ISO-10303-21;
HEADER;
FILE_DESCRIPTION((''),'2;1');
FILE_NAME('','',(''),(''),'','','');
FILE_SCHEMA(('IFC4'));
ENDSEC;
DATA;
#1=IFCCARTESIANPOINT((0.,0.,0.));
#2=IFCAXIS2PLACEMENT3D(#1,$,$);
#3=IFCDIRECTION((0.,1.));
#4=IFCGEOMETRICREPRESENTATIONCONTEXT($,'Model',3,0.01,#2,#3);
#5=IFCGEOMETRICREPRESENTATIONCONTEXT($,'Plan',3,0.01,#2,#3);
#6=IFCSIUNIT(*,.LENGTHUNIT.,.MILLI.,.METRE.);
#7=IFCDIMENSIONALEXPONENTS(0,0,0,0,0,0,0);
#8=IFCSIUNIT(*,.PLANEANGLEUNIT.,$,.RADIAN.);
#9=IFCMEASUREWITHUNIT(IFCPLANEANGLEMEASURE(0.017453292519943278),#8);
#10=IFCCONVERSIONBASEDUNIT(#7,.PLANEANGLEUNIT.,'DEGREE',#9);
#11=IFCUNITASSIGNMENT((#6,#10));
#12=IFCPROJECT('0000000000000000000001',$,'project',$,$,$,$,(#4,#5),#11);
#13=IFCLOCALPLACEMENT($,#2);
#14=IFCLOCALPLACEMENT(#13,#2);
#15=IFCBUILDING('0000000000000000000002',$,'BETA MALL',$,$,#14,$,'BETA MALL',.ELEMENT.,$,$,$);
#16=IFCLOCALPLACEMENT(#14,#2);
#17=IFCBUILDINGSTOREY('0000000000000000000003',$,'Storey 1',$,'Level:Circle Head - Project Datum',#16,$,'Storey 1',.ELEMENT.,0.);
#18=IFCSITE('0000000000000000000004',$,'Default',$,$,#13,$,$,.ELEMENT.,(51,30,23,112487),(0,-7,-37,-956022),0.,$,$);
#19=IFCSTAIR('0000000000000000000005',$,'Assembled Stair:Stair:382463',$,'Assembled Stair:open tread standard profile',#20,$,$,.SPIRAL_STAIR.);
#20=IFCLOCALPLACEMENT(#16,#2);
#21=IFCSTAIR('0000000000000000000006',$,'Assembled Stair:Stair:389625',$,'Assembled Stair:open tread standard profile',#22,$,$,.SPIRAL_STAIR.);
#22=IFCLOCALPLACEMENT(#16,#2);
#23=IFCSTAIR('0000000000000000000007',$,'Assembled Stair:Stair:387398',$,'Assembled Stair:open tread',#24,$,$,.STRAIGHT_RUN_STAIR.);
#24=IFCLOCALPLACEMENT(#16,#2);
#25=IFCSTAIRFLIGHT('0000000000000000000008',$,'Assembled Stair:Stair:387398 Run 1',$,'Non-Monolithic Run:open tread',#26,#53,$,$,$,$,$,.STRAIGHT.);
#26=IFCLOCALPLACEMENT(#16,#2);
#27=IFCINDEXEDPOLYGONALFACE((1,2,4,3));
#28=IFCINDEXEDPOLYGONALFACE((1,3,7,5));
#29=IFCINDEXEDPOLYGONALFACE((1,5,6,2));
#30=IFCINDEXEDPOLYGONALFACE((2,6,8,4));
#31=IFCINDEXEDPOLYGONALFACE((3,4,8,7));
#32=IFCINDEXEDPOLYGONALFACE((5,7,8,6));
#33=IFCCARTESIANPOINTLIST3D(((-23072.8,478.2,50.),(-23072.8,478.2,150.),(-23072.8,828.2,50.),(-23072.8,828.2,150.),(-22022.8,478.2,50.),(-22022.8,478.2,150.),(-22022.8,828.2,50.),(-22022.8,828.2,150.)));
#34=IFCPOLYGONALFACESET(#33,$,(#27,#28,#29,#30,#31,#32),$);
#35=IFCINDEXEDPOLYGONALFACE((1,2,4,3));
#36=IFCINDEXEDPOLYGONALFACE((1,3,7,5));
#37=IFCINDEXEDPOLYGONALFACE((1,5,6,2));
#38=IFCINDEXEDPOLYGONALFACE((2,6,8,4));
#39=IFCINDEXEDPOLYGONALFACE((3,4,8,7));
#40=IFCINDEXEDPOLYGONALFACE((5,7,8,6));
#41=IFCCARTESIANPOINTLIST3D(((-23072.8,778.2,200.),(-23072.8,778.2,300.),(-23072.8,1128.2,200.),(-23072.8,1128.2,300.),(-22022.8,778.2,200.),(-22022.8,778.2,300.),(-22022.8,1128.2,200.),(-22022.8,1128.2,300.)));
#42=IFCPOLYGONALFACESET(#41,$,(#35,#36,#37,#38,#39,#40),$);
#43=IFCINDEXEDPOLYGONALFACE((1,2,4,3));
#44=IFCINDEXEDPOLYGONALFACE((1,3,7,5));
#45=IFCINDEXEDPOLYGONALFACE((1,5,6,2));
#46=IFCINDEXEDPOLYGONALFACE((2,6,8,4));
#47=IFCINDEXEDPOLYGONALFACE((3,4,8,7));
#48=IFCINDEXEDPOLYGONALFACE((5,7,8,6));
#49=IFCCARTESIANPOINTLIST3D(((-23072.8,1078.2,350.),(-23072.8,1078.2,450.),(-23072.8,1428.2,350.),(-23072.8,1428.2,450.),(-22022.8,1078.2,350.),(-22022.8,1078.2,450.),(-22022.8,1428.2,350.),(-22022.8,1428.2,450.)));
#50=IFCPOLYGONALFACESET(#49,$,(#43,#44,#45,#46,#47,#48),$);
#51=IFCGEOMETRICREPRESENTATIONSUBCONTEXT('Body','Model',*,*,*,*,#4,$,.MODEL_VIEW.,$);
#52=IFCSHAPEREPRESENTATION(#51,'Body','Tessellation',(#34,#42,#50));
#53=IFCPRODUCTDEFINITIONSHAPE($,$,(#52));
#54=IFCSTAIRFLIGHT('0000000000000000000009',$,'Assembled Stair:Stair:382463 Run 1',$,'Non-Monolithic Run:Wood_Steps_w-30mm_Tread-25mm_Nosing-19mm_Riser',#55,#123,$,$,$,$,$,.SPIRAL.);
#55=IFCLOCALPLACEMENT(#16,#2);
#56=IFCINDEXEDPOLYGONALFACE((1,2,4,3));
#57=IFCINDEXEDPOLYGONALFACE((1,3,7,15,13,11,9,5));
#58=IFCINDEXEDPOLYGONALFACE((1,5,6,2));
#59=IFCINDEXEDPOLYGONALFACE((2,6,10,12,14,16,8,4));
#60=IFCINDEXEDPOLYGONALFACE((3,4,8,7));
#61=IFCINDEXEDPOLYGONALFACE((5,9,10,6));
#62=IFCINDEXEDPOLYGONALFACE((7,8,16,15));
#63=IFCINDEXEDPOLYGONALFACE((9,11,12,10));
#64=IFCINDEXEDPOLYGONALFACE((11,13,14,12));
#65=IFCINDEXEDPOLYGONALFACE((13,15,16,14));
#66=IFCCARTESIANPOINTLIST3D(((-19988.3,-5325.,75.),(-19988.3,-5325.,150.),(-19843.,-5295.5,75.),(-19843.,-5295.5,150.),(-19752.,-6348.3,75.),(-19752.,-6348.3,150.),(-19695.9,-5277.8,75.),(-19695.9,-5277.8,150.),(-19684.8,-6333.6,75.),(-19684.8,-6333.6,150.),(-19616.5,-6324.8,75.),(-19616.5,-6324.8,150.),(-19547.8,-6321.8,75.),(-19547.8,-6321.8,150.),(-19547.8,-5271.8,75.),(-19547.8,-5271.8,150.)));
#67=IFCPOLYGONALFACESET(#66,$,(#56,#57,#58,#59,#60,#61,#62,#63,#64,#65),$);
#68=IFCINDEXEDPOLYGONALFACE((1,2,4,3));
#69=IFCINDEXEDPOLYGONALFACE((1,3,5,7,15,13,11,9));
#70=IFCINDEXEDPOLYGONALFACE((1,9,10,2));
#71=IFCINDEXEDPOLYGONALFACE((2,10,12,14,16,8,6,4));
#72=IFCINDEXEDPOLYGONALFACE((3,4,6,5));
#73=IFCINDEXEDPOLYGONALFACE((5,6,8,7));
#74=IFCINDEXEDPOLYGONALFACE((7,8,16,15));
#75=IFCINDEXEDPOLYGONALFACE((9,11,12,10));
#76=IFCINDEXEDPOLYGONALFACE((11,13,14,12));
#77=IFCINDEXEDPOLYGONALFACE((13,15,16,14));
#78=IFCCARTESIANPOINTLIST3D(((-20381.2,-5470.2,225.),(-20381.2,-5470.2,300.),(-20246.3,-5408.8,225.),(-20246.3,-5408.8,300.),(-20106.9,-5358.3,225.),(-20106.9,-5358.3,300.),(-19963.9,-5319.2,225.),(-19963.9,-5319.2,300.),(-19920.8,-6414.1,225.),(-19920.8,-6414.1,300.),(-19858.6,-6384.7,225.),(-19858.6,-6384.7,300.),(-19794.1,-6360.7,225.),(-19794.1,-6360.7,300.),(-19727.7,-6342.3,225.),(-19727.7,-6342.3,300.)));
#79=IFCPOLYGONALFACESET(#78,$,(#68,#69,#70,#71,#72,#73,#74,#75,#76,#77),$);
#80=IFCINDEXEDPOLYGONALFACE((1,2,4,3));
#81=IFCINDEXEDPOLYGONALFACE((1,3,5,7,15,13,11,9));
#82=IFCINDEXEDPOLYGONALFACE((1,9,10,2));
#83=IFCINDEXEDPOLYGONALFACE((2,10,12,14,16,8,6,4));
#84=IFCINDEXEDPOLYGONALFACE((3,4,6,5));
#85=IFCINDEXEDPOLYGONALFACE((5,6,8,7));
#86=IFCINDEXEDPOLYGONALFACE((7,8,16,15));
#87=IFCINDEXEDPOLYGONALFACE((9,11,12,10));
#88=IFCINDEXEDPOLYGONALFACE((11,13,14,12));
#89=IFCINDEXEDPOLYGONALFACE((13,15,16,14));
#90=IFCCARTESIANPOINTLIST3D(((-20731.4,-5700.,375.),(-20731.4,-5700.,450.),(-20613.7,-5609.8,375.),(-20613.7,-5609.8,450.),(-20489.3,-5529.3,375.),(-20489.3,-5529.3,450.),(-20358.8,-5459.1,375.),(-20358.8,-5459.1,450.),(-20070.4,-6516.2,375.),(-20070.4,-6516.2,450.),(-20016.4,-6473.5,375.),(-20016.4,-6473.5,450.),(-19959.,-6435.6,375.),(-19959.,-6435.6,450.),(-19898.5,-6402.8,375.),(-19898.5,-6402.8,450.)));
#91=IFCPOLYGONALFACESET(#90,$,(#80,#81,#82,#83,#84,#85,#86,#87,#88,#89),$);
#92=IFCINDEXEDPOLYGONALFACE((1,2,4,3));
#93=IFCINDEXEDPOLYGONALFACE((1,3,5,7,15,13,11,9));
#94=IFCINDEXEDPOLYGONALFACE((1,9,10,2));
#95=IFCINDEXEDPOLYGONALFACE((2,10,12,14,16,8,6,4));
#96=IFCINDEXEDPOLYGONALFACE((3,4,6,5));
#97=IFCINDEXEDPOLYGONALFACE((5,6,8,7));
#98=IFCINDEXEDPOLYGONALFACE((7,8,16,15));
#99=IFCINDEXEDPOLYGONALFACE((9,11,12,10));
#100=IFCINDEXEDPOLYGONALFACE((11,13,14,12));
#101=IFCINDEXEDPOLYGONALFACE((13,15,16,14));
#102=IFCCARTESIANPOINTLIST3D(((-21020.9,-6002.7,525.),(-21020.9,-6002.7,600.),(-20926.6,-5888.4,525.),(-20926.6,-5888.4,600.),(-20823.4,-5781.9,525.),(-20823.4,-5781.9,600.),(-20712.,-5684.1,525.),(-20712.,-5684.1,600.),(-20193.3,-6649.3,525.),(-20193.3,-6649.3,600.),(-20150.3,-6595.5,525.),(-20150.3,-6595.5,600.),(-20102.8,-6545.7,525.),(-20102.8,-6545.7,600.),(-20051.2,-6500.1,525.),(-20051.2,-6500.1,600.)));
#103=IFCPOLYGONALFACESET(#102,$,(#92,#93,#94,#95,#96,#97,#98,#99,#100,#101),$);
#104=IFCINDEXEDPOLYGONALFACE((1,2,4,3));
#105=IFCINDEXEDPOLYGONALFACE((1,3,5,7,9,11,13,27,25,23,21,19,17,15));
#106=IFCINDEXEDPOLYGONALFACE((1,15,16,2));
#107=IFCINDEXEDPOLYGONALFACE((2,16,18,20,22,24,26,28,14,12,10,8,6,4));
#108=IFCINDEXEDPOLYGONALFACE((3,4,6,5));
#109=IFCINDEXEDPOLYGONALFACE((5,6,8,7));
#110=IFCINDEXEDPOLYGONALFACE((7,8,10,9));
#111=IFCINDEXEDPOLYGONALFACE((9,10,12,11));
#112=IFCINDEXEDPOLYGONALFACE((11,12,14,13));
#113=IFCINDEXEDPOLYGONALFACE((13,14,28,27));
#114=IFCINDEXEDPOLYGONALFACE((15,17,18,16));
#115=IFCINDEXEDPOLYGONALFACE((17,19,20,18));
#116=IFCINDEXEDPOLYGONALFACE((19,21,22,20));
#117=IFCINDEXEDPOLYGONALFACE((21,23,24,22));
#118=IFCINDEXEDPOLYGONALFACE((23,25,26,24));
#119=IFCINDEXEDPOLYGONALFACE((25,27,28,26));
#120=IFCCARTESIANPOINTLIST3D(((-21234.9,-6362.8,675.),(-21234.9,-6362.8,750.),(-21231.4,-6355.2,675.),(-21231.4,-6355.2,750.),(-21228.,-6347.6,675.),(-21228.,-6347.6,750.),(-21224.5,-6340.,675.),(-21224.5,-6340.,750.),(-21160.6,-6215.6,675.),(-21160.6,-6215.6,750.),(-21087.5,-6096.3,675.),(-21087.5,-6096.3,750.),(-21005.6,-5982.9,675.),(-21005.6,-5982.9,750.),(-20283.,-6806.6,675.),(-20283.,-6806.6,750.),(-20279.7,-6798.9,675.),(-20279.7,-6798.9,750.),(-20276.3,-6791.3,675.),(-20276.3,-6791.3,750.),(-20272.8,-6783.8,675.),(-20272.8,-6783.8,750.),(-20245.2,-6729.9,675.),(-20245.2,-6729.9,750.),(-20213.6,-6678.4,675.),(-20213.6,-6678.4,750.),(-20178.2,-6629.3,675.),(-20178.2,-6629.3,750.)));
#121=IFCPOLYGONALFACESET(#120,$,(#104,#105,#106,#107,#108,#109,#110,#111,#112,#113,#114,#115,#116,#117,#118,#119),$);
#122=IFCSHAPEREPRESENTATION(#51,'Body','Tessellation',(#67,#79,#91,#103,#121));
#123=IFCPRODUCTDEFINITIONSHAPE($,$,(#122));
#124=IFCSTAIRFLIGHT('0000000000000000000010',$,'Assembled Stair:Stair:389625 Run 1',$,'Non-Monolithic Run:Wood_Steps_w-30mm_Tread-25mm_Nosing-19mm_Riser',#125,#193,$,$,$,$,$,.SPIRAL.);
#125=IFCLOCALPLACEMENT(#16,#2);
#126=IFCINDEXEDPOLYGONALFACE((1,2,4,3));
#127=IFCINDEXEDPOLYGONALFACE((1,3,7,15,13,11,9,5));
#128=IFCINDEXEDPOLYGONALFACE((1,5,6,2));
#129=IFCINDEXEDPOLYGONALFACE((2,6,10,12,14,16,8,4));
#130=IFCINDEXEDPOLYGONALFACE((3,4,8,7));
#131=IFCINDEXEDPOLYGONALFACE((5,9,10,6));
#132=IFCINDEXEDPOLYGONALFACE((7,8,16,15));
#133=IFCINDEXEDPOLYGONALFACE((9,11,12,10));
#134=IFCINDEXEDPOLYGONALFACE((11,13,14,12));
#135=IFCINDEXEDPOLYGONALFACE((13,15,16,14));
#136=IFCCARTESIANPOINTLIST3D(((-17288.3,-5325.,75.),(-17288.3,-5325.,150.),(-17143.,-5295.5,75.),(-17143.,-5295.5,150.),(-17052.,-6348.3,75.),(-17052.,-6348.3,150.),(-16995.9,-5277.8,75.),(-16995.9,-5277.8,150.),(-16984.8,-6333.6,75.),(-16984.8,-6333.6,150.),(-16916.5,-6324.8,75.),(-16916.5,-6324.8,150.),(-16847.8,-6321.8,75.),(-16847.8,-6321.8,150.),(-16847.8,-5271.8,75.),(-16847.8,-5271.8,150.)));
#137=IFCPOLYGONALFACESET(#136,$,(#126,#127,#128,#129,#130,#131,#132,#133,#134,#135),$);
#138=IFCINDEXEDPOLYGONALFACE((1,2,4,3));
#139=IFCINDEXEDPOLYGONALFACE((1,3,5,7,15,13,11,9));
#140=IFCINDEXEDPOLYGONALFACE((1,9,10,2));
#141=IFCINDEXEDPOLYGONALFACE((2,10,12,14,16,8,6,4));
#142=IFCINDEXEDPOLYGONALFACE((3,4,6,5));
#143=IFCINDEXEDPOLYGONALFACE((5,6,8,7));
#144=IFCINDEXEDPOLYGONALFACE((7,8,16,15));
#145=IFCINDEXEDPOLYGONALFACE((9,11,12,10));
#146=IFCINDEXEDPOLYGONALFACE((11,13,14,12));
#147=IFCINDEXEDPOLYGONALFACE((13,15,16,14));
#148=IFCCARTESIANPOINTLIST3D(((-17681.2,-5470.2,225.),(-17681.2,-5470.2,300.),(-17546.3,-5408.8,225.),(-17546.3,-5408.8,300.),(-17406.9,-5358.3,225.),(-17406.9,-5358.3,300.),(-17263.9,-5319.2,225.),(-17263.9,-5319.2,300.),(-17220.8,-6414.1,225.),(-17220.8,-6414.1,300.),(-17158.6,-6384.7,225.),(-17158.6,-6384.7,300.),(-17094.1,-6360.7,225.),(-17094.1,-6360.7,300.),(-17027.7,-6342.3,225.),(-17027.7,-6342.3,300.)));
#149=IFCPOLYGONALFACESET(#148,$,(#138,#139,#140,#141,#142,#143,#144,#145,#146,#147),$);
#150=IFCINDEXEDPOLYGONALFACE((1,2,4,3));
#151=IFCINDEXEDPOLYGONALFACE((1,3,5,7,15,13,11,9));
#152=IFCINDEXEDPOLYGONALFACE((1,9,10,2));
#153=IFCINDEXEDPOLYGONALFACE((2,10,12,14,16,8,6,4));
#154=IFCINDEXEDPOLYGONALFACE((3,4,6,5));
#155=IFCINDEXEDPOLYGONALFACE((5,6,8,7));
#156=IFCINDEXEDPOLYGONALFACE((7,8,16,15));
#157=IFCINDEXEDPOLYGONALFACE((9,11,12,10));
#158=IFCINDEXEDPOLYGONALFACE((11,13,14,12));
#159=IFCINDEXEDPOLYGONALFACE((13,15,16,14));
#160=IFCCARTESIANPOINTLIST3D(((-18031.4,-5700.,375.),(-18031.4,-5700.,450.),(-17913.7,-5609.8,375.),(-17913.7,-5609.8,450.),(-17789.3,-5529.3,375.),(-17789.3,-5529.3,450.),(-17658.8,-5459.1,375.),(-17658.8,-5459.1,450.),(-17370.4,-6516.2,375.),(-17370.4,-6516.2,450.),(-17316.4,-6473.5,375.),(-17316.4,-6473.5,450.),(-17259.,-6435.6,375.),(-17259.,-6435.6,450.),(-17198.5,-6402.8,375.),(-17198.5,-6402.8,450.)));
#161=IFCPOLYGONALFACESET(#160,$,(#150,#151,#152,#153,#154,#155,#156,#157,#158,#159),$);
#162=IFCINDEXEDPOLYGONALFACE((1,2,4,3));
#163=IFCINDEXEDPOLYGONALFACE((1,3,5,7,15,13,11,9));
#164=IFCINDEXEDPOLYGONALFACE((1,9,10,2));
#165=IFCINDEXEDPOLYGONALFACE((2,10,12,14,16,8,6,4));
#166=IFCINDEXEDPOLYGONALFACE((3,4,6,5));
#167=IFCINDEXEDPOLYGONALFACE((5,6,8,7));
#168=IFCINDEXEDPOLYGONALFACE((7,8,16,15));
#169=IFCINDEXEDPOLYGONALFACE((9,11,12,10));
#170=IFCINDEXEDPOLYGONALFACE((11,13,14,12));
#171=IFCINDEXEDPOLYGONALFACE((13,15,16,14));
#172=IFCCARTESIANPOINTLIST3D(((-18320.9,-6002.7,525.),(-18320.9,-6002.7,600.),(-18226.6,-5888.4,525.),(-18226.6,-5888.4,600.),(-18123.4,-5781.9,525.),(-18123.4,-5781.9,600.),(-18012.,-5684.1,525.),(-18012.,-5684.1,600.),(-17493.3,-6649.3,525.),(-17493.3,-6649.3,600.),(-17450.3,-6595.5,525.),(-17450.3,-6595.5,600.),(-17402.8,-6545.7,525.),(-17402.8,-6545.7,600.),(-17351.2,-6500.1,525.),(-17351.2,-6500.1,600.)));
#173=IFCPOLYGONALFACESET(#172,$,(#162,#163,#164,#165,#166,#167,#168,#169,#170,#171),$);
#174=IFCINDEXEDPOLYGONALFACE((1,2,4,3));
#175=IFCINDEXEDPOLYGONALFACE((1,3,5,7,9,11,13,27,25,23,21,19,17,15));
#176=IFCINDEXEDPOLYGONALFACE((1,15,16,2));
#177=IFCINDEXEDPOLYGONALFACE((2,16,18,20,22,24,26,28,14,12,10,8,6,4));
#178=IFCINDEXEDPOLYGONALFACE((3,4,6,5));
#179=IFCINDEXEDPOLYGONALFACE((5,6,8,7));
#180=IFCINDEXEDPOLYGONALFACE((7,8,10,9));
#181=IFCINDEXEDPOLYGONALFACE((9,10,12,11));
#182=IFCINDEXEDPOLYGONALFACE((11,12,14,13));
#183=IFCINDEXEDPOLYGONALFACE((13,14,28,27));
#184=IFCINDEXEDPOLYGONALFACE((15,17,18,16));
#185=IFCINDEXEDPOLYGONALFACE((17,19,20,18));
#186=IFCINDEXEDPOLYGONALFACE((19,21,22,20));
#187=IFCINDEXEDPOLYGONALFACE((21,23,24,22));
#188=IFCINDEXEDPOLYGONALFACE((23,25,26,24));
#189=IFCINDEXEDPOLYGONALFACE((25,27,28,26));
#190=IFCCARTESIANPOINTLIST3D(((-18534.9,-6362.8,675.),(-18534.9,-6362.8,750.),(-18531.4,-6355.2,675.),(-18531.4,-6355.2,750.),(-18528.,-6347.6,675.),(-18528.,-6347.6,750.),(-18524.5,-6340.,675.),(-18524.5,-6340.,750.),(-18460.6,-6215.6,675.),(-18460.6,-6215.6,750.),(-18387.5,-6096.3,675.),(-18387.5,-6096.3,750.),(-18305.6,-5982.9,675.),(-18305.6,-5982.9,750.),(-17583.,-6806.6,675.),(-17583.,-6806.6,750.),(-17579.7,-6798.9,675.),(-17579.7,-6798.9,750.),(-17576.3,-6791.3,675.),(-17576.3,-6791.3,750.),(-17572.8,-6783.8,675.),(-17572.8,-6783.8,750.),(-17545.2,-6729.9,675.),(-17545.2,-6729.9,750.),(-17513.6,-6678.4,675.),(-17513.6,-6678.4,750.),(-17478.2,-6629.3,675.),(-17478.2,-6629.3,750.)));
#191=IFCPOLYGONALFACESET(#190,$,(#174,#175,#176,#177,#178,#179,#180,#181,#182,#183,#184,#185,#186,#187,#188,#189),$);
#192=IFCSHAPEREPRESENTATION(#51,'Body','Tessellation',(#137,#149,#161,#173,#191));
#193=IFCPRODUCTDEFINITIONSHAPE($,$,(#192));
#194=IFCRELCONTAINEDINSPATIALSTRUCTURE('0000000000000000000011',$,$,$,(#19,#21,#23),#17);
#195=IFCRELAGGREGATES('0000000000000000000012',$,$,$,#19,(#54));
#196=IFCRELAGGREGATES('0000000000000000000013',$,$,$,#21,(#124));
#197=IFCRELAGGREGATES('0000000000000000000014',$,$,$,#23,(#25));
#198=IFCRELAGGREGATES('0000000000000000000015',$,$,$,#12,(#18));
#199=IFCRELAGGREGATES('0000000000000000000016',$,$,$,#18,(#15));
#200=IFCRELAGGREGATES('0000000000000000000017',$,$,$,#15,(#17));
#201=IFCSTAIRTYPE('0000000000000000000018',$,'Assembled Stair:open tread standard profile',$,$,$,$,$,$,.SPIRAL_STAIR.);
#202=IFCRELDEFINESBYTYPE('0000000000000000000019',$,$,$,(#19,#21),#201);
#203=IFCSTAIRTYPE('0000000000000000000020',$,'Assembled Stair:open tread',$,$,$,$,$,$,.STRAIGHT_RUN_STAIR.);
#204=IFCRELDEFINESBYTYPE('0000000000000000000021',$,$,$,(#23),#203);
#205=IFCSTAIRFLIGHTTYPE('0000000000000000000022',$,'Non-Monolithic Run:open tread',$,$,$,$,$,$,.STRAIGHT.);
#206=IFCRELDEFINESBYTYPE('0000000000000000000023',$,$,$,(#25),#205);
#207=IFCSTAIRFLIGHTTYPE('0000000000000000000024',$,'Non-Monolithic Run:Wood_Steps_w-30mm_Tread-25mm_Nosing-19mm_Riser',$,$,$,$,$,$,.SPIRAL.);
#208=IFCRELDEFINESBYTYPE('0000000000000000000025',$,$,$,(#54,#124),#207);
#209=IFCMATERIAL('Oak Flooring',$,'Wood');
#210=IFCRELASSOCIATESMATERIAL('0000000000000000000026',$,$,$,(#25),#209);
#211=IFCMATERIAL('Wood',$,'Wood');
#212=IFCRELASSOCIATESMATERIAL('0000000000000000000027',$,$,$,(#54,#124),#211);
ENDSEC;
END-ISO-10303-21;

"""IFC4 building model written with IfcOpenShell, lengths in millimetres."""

from ifc_helpers import new_model, entity, si_unit, converted_unit, direction, frame, origin, place, context, subcontext, project, spatial, line, arc, indexed_curve, outline, extrude, material, type_object, element, aggregate, save


model = new_model("IFC4")

# Units and contexts
model_context = context("Model", 3, precision=0.01, world=origin(), true_north=direction((0.0, 1.0)))
plan_context = context("Plan", 3, precision=0.01, world=origin(), true_north=direction((0.0, 1.0)))
body_context = subcontext(model_context, "Body", "Model", "MODEL_VIEW")
ifc_project = project(units=[si_unit("LENGTHUNIT", "METRE", prefix="MILLI"), converted_unit("PLANEANGLEUNIT", "DEGREE", entity("IfcPlaneAngleMeasure", 0.017453292519943278), si_unit("PLANEANGLEUNIT", "RADIAN"), dimensions=[0, 0, 0, 0, 0, 0, 0])], contexts=[model_context, plan_context])

# Site, building, storey
site_placement = place(None, origin())
site = spatial("IfcSite", under=ifc_project, at=site_placement, Name="Default", CompositionType="ELEMENT", RefLatitude=(51, 30, 23, 112487), RefLongitude=(0, -7, -37, -956022), RefElevation=0.0)
building_placement = place(site_placement, origin())
building = spatial("IfcBuilding", under=site, at=building_placement, Name="BETA MALL", LongName="BETA MALL", CompositionType="ELEMENT")
storey_placement = place(building_placement, origin())
storey = spatial("IfcBuildingStorey", under=building, at=storey_placement, Name="Storey 1", ObjectType="Level:Circle Head - Project Datum", LongName="Storey 1", CompositionType="ELEMENT", Elevation=0.0)

# Stairs
stair_type_1 = type_object("IfcStairType", Name="Assembled Stair:open tread standard profile", PredefinedType="SPIRAL_STAIR")
stair_1_placement = place(storey_placement, origin())
stair_1 = element("IfcStair", 1, at=stair_1_placement, inside=storey, type_object=stair_type_1, Name="Assembled Stair:Stair:382463", ObjectType="Assembled Stair:open tread standard profile", PredefinedType="SPIRAL_STAIR")
ifc_material_1 = material(Name="Wood", Category="Wood")
stair_2_placement = place(storey_placement, origin())
stair_2 = element("IfcStair", 2, at=stair_2_placement, inside=storey, type_object=stair_type_1, Name="Assembled Stair:Stair:389625", ObjectType="Assembled Stair:open tread standard profile", PredefinedType="SPIRAL_STAIR")

# Stair, stair flight
stair_type_2 = type_object("IfcStairType", Name="Assembled Stair:open tread", PredefinedType="STRAIGHT_RUN_STAIR")
ifc_material_2 = material(Name="Oak Flooring", Category="Wood")
stair_flight_type_1 = type_object("IfcStairFlightType", Name="Non-Monolithic Run:open tread", PredefinedType="STRAIGHT")
stair_3_placement = place(storey_placement, origin())
stair_3 = element("IfcStair", 3, at=stair_3_placement, inside=storey, type_object=stair_type_2, Name="Assembled Stair:Stair:387398", ObjectType="Assembled Stair:open tread", PredefinedType="STRAIGHT_RUN_STAIR")
stair_flight_1_placement = place(stair_3_placement, origin())
stair_flight_1 = element("IfcStairFlight", 4, at=stair_flight_1_placement, type_object=stair_flight_type_1, material=ifc_material_2, Name="Assembled Stair:Stair:387398 Run 1", ObjectType="Non-Monolithic Run:open tread", PredefinedType="STRAIGHT", context=body_context, shape_type="SweptSolid", body=[
    extrude(outline(indexed_curve([(-525.0, -175.0), (525.0, -175.0), (525.0, 175.0), (-525.0, 175.0), (-525.0, -175.0)], self_intersect=False)), frame((-22547.8, 653.2, 50.0), z_axis=(0.0, 0.0, 1.0), x_axis=(-1.0, 0.0, 0.0)), (0.0, 0.0, 1.0), 100.0),
    extrude(outline(indexed_curve([(-525.0, -175.0), (525.0, -175.0), (525.0, 175.0), (-525.0, 175.0), (-525.0, -175.0)], self_intersect=False)), frame((-22547.8, 953.2, 200.0), z_axis=(0.0, 0.0, 1.0), x_axis=(-1.0, 0.0, 0.0)), (0.0, 0.0, 1.0), 100.0),
    extrude(outline(indexed_curve([(-525.0, -175.0), (525.0, -175.0), (525.0, 175.0), (-525.0, 175.0), (-525.0, -175.0)], self_intersect=False)), frame((-22547.8, 1253.2, 350.0), z_axis=(0.0, 0.0, 1.0), x_axis=(-1.0, 0.0, 0.0)), (0.0, 0.0, 1.0), 100.0),
])

# Stair flights
stair_flight_type_2 = type_object("IfcStairFlightType", Name="Non-Monolithic Run:Wood_Steps_w-30mm_Tread-25mm_Nosing-19mm_Riser", PredefinedType="SPIRAL")
stair_flight_2_placement = place(stair_1_placement, origin())
stair_flight_2 = element("IfcStairFlight", 5, at=stair_flight_2_placement, type_object=stair_flight_type_2, material=ifc_material_1, Name="Assembled Stair:Stair:382463 Run 1", ObjectType="Non-Monolithic Run:Wood_Steps_w-30mm_Tread-25mm_Nosing-19mm_Riser", PredefinedType="SPIRAL", context=body_context, shape_type="SweptSolid", body=[
    extrude(outline(indexed_curve([(-43.1, 531.6), (-279.3, -491.7), (-60.7, -531.6), (161.2, -544.9), (161.2, 505.1), (58.2, 511.7)], segments=[line(1, 2), arc(2, 3, 4), line(4, 5), arc(5, 6, 1)], self_intersect=False)), frame((-19708.9, -5816.7, 75.0), z_axis=(0.0, 0.0, -1.0), x_axis=(1.0, 0.0, 0.0)), (0.0, 0.0, -1.0), 75.0),
    extrude(outline(indexed_curve([(77.6, 527.6), (-382.8, -416.3), (-178.7, -504.3), (34.5, -567.2), (270.7, 455.9), (171.8, 485.5)], segments=[line(1, 2), arc(2, 3, 4), line(4, 5), arc(5, 6, 1)], self_intersect=False)), frame((-19998.4, -5886.5, 225.0), z_axis=(0.0, 0.0, -1.0), x_axis=(1.0, 0.0, 0.0)), (0.0, 0.0, -1.0), 75.0),
    extrude(outline(indexed_curve([(77.6, 527.6), (-382.8, -416.3), (-178.7, -504.3), (34.5, -567.2), (270.7, 455.9), (171.8, 485.5)], segments=[line(1, 2), arc(2, 3, 4), line(4, 5), arc(5, 6, 1)], self_intersect=False)), frame((-20264.8, -6019.5, 375.0), z_axis=(0.0, 0.0, -1.0), x_axis=(0.974368, 0.22496, 0.0)), (0.0, 0.0, -1.0), 75.0),
    extrude(outline(indexed_curve([(77.6, 527.6), (-382.8, -416.3), (-178.7, -504.3), (34.5, -567.2), (270.7, 455.9), (171.8, 485.5)], segments=[line(1, 2), arc(2, 3, 4), line(4, 5), arc(5, 6, 1)], self_intersect=False)), frame((-20494.4, -6209.0, 525.0), z_axis=(0.0, 0.0, -1.0), x_axis=(0.898786, 0.438387, 0.0)), (0.0, 0.0, -1.0), 75.0),
    extrude(outline(indexed_curve([(-124.0, 512.1), (-107.6, -538.0), (-95.1, -537.9), (-82.6, -537.8), (126.6, -522.6), (332.8, -483.9), (80.6, 535.4), (-8.6, 518.7), (-99.0, 512.1), (-111.5, 512.0)], segments=[line(1, 2), arc(2, 3, 4), arc(4, 5, 6), line(6, 7), arc(7, 8, 9), arc(9, 10, 1)], self_intersect=False)), frame((-20699.8, -6484.2, 675.0), z_axis=(0.0, 0.0, -1.0), x_axis=(0.408364, 0.912819, 0.0)), (0.0, 0.0, -1.0), 75.0),
])
aggregate(stair_1, [stair_flight_2])
stair_flight_3_placement = place(stair_2_placement, origin())
stair_flight_3 = element("IfcStairFlight", 6, at=stair_flight_3_placement, type_object=stair_flight_type_2, material=ifc_material_1, Name="Assembled Stair:Stair:389625 Run 1", ObjectType="Non-Monolithic Run:Wood_Steps_w-30mm_Tread-25mm_Nosing-19mm_Riser", PredefinedType="SPIRAL", context=body_context, shape_type="SweptSolid", body=[
    extrude(outline(indexed_curve([(-43.1, 531.6), (-279.3, -491.7), (-60.7, -531.6), (161.2, -544.9), (161.2, 505.1), (58.2, 511.7)], segments=[line(1, 2), arc(2, 3, 4), line(4, 5), arc(5, 6, 1)], self_intersect=False)), frame((-17008.9, -5816.7, 75.0), z_axis=(0.0, 0.0, -1.0), x_axis=(1.0, 0.0, 0.0)), (0.0, 0.0, -1.0), 75.0),
    extrude(outline(indexed_curve([(77.6, 527.6), (-382.8, -416.3), (-178.7, -504.3), (34.5, -567.2), (270.7, 455.9), (171.8, 485.5)], segments=[line(1, 2), arc(2, 3, 4), line(4, 5), arc(5, 6, 1)], self_intersect=False)), frame((-17298.4, -5886.5, 225.0), z_axis=(0.0, 0.0, -1.0), x_axis=(1.0, 0.0, 0.0)), (0.0, 0.0, -1.0), 75.0),
    extrude(outline(indexed_curve([(77.6, 527.6), (-382.8, -416.3), (-178.7, -504.3), (34.5, -567.2), (270.7, 455.9), (171.8, 485.5)], segments=[line(1, 2), arc(2, 3, 4), line(4, 5), arc(5, 6, 1)], self_intersect=False)), frame((-17564.8, -6019.5, 375.0), z_axis=(0.0, 0.0, -1.0), x_axis=(0.974368, 0.22496, 0.0)), (0.0, 0.0, -1.0), 75.0),
    extrude(outline(indexed_curve([(77.6, 527.6), (-382.8, -416.3), (-178.7, -504.3), (34.5, -567.2), (270.7, 455.9), (171.8, 485.5)], segments=[line(1, 2), arc(2, 3, 4), line(4, 5), arc(5, 6, 1)], self_intersect=False)), frame((-17794.4, -6209.0, 525.0), z_axis=(0.0, 0.0, -1.0), x_axis=(0.898786, 0.438387, 0.0)), (0.0, 0.0, -1.0), 75.0),
    extrude(outline(indexed_curve([(-124.0, 512.1), (-107.6, -538.0), (-95.1, -537.9), (-82.6, -537.8), (126.6, -522.6), (332.8, -483.9), (80.6, 535.4), (-8.6, 518.7), (-99.0, 512.1), (-111.5, 512.0)], segments=[line(1, 2), arc(2, 3, 4), arc(4, 5, 6), line(6, 7), arc(7, 8, 9), arc(9, 10, 1)], self_intersect=False)), frame((-17999.8, -6484.2, 675.0), z_axis=(0.0, 0.0, -1.0), x_axis=(0.408364, 0.912819, 0.0)), (0.0, 0.0, -1.0), 75.0),
])
aggregate(stair_2, [stair_flight_3])

aggregate(stair_3, [stair_flight_1])

save(model, "model.ifc")
